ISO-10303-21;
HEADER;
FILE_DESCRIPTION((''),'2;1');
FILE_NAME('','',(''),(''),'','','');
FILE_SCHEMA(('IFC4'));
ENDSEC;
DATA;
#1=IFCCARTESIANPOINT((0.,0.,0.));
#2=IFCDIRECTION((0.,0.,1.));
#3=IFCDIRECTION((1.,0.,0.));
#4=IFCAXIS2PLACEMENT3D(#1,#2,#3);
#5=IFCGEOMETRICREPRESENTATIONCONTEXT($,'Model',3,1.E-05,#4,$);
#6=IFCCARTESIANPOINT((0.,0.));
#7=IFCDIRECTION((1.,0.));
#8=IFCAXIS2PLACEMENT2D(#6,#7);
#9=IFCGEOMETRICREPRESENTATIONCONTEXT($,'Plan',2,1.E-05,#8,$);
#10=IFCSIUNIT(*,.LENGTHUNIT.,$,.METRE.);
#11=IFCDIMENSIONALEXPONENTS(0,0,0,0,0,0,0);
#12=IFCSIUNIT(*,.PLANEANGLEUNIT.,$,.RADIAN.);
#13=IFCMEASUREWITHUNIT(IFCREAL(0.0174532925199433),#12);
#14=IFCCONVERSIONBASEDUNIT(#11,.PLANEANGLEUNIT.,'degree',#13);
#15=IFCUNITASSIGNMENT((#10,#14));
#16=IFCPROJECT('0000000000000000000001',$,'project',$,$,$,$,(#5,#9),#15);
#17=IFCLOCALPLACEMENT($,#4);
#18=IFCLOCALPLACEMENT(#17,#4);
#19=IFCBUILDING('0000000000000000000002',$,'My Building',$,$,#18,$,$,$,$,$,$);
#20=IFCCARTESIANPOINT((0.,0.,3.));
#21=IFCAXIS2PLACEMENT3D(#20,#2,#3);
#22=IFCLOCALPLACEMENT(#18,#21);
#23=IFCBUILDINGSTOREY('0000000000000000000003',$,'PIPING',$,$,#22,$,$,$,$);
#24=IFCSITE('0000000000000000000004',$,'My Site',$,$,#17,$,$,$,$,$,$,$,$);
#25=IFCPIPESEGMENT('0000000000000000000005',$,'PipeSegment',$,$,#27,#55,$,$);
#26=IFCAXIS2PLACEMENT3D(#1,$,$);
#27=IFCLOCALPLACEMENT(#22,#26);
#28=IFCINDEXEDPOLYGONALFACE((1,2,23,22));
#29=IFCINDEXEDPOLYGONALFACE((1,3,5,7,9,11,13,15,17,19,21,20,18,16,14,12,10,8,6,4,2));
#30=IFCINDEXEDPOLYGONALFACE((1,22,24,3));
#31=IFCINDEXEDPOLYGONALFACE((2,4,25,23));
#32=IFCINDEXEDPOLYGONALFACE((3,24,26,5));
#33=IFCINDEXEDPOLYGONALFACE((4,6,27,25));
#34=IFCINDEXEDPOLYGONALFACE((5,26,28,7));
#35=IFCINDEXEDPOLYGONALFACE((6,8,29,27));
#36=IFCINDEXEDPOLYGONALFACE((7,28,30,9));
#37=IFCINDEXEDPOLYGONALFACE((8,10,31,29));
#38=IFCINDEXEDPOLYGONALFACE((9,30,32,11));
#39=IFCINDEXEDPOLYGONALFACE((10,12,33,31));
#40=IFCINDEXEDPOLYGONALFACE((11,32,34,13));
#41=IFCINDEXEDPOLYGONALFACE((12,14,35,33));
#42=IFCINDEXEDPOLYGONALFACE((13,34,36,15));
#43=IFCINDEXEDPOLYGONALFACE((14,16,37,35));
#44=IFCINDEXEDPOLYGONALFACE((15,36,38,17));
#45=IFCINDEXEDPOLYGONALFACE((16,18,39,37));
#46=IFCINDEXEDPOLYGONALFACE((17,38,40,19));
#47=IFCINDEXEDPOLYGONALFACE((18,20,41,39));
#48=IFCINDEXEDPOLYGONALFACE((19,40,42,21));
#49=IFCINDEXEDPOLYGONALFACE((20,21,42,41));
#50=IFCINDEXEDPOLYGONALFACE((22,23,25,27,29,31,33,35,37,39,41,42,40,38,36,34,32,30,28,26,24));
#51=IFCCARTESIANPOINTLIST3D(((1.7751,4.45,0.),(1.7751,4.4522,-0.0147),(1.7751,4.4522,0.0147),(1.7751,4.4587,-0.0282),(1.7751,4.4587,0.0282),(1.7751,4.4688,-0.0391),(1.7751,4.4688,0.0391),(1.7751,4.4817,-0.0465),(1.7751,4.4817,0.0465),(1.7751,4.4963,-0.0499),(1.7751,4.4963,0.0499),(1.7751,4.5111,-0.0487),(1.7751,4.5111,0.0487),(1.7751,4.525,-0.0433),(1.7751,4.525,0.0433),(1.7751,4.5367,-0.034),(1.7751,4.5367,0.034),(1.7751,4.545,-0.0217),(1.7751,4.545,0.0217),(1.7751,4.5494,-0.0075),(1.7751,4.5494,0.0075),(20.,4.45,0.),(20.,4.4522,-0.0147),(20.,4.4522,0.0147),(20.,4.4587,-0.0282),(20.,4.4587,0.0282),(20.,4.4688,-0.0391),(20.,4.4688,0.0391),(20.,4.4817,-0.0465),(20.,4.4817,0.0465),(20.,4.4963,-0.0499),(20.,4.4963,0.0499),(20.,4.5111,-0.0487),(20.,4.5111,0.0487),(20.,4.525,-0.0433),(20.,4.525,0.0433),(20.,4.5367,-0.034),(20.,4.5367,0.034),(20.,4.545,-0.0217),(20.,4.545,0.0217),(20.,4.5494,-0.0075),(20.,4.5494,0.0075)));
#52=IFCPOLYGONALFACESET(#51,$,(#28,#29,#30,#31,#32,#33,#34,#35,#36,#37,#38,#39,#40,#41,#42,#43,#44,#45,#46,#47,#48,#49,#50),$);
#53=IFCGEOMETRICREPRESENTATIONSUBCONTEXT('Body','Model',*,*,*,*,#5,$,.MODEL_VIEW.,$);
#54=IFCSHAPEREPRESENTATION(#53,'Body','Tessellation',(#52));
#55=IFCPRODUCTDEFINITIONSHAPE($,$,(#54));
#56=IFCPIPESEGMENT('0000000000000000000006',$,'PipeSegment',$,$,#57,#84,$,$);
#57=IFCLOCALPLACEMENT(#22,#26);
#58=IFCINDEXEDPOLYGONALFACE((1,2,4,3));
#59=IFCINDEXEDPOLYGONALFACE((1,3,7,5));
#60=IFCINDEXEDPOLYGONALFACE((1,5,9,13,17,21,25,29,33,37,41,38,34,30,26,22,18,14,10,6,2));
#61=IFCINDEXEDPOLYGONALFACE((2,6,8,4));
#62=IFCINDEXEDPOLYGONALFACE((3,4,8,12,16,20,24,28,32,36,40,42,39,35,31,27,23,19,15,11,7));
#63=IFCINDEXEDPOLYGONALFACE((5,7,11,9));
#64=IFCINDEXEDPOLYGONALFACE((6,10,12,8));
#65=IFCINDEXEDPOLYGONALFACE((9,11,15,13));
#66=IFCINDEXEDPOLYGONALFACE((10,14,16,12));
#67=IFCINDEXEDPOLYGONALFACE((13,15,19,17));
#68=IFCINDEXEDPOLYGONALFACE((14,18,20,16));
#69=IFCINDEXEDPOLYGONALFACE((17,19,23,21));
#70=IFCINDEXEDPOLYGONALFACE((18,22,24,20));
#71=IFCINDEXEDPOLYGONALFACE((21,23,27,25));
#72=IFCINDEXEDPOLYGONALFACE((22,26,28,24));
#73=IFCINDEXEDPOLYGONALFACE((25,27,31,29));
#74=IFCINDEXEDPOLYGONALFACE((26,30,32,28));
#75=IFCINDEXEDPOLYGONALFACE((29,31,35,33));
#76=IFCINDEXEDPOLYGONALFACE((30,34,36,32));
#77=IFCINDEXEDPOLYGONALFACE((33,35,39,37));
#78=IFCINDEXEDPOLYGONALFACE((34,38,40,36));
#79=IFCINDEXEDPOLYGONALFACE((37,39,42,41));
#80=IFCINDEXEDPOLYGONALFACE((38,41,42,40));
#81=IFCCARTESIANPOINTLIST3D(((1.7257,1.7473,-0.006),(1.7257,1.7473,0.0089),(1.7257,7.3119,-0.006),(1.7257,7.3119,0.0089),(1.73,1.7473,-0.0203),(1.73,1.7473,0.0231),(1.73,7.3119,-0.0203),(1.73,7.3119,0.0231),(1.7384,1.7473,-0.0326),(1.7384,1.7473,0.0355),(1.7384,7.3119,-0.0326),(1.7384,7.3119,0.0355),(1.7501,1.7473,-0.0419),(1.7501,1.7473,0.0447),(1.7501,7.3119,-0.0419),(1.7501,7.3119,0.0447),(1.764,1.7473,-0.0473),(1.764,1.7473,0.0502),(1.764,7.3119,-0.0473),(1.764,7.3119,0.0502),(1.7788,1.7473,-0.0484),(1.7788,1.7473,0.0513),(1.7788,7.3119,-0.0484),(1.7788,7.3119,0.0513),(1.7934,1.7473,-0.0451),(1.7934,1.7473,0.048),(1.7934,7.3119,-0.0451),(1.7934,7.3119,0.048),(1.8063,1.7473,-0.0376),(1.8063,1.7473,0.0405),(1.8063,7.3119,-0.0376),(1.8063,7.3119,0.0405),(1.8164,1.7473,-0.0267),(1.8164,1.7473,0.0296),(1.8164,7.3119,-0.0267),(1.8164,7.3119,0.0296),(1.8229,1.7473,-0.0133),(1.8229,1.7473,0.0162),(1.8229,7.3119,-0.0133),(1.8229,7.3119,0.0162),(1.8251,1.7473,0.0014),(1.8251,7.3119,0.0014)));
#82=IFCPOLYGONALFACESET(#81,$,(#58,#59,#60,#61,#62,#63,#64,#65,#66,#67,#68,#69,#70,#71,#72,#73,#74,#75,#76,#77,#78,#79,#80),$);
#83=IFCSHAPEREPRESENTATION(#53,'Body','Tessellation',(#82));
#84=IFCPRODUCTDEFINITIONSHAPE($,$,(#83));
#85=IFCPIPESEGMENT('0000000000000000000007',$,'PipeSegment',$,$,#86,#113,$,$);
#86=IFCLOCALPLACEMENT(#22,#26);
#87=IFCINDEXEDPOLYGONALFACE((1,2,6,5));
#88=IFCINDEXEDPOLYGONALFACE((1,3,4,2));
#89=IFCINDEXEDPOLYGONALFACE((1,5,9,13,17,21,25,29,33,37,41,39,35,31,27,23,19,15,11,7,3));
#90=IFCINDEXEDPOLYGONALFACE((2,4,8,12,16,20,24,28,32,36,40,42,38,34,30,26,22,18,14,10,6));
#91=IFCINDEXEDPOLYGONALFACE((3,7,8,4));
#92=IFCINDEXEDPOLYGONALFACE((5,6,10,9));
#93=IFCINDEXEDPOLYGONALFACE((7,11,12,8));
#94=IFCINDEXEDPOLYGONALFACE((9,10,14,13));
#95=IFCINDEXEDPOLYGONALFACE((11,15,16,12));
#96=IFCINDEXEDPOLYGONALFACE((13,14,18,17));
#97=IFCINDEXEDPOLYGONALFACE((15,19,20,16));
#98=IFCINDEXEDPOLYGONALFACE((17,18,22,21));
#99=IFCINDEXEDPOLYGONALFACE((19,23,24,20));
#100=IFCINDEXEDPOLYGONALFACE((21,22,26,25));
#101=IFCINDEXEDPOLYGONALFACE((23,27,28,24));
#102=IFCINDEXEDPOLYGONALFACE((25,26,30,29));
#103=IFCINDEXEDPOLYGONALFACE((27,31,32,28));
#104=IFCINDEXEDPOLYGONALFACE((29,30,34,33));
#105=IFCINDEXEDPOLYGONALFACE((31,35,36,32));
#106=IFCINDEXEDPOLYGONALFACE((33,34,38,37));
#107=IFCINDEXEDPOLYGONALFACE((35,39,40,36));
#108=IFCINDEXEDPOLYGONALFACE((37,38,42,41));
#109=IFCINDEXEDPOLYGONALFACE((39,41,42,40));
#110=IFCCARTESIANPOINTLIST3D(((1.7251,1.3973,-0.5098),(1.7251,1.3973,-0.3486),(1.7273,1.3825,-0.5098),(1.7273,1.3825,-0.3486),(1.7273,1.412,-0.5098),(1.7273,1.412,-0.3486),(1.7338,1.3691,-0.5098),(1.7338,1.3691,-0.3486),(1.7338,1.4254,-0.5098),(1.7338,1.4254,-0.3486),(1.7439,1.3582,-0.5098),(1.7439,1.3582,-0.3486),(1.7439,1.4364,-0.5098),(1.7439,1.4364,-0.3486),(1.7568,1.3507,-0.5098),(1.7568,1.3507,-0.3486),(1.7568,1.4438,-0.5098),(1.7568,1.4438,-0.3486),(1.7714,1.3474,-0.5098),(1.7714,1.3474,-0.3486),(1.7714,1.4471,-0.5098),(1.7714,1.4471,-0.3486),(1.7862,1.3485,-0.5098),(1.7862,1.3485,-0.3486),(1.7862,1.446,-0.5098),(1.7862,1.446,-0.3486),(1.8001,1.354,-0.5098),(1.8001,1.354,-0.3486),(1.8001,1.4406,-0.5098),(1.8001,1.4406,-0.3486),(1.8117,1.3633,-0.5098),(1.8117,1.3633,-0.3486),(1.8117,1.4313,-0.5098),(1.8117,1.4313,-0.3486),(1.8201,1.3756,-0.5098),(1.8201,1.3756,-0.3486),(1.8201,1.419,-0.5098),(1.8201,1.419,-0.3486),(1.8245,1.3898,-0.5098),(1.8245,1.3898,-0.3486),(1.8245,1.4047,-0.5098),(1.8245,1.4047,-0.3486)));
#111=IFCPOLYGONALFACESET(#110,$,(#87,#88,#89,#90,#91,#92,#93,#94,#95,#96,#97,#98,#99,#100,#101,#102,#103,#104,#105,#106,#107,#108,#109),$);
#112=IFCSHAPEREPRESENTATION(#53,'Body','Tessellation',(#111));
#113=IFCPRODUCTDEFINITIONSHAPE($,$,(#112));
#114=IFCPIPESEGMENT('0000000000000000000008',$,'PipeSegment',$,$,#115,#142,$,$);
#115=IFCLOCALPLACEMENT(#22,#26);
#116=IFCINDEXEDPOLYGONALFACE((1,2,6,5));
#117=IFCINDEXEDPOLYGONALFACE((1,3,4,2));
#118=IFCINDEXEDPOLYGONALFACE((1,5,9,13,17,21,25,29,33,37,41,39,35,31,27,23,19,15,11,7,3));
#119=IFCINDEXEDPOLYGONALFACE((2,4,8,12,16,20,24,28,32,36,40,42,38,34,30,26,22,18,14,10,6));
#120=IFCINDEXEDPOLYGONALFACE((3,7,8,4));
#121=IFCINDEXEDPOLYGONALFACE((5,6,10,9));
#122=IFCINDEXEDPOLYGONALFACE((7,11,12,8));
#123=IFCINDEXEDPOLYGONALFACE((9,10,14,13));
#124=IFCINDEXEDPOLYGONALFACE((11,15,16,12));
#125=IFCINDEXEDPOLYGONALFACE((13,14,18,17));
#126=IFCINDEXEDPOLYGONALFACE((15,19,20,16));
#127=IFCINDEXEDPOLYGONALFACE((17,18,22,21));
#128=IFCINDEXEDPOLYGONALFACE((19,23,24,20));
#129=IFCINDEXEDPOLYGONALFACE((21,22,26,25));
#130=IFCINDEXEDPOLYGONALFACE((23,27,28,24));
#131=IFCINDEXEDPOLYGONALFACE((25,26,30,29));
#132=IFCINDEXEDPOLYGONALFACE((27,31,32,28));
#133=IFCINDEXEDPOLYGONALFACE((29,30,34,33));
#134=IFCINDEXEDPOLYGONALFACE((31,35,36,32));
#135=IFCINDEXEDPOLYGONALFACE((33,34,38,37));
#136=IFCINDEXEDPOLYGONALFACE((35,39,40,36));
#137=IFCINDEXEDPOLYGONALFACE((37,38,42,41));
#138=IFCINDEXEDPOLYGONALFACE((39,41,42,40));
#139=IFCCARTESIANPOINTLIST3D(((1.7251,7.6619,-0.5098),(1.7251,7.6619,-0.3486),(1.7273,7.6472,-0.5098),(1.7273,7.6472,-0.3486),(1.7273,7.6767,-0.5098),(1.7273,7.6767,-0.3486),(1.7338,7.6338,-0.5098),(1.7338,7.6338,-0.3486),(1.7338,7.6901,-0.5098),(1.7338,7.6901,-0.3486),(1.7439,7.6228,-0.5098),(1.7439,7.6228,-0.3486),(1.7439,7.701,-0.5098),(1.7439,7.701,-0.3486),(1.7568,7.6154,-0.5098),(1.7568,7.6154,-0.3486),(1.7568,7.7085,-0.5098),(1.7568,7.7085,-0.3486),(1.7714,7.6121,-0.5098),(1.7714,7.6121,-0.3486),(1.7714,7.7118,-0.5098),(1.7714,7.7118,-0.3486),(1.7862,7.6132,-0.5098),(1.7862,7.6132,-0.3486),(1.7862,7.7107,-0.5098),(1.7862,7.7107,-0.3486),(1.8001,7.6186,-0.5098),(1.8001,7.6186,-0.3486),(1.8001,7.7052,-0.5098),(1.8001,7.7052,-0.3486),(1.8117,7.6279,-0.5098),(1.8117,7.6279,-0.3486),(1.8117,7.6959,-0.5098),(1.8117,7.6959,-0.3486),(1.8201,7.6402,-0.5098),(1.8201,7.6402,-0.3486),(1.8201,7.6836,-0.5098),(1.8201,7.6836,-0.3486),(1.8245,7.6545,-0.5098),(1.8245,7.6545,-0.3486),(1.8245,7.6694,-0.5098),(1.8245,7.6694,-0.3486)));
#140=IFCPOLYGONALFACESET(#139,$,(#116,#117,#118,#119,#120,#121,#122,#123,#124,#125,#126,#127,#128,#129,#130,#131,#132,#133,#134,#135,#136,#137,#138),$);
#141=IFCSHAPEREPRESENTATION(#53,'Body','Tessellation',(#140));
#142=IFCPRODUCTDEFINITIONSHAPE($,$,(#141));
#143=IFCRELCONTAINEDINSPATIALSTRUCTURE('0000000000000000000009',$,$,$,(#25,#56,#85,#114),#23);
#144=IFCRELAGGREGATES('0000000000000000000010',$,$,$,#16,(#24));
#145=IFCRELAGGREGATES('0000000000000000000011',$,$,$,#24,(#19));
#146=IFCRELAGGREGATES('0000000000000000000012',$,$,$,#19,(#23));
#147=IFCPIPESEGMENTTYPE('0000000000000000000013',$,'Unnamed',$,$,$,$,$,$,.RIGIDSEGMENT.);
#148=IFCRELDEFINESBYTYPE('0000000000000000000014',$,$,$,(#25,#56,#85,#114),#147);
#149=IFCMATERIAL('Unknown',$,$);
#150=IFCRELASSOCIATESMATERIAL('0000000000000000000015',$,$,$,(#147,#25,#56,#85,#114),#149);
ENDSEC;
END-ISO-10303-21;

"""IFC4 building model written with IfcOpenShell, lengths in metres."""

from ifc_helpers import new_model, entity, si_unit, converted_unit, frame, origin_with_axes, origin_2d_with_axis, place, context, subcontext, project, spatial, circle, extrude, material, material_profile, profile_set, profile_usage, type_object, element, save


model = new_model("IFC4")

# Units and contexts
model_context = context("Model", 3, precision=1e-05, world=origin_with_axes())
plan_context = context("Plan", 2, precision=1e-05, world=origin_2d_with_axis())
body_context = subcontext(model_context, "Body", "Model", "MODEL_VIEW")
ifc_project = project(units=[si_unit("LENGTHUNIT", "METRE"), converted_unit("PLANEANGLEUNIT", "degree", entity("IfcReal", 0.0174532925199433), si_unit("PLANEANGLEUNIT", "RADIAN"), dimensions=[0, 0, 0, 0, 0, 0, 0])], contexts=[model_context, plan_context])

# Site, building, storey
site_placement = place(None, origin_with_axes())
site = spatial("IfcSite", under=ifc_project, at=site_placement, Name="My Site")
building_placement = place(site_placement, origin_with_axes())
building = spatial("IfcBuilding", under=site, at=building_placement, Name="My Building")
storey_placement = place(building_placement, frame((0.0, 0.0, 3.0), z_axis=(0.0, 0.0, 1.0), x_axis=(1.0, 0.0, 0.0)))
storey = spatial("IfcBuildingStorey", under=building, at=storey_placement, Name="PIPING")

# Pipe segments
ifc_material = material(Name="Unknown")
ifc_material_profile = material_profile(ifc_material, circle(Radius=0.05))
ifc_profile_set = profile_set([ifc_material_profile])
ifc_profile_usage_1 = profile_usage(ifc_profile_set, cardinal=5)
pipe_segment_type = type_object("IfcPipeSegmentType", Name="Unnamed", PredefinedType="RIGIDSEGMENT", material=ifc_profile_set)
pipe_segment_1_placement = place(storey_placement, frame((20.0, 4.5, 0.0), z_axis=(-1.0, 0.0, 0.0), x_axis=(0.0, -1.0, 0.0)))
element("IfcPipeSegment", 1, at=pipe_segment_1_placement, inside=storey, type_object=pipe_segment_type, material=ifc_profile_usage_1, Name="PipeSegment", context=body_context, shape_type="SweptSolid", body=[
    extrude(circle(Radius=0.05), origin_with_axes(), (0.0, 0.0, 1.0), 18.2249),
])
ifc_profile_usage_2 = profile_usage(ifc_profile_set, cardinal=5)
pipe_segment_2_placement = place(storey_placement, frame((1.7751, 1.7473, 0.0014), z_axis=(0.0, 1.0, 0.0), x_axis=(1.0, 0.0, 0.0)))
element("IfcPipeSegment", 2, at=pipe_segment_2_placement, inside=storey, type_object=pipe_segment_type, material=ifc_profile_usage_2, Name="PipeSegment", context=body_context, shape_type="SweptSolid", body=[
    extrude(circle(Radius=0.05), origin_with_axes(), (0.0, 0.0, 1.0), 5.5647),
])
ifc_profile_usage_3 = profile_usage(ifc_profile_set, cardinal=5)
pipe_segment_3_placement = place(storey_placement, frame((1.7751, 1.3973, -0.3486), z_axis=(0.0, 0.0, -1.0), x_axis=(-1.0, 0.0, 0.0)))
element("IfcPipeSegment", 3, at=pipe_segment_3_placement, inside=storey, type_object=pipe_segment_type, material=ifc_profile_usage_3, Name="PipeSegment", context=body_context, shape_type="SweptSolid", body=[
    extrude(circle(Radius=0.05), origin_with_axes(), (0.0, 0.0, 1.0), 0.1612),
])
ifc_profile_usage_4 = profile_usage(ifc_profile_set, cardinal=5)
pipe_segment_4_placement = place(storey_placement, frame((1.7751, 7.6619, -0.3486), z_axis=(0.0, 0.0, -1.0), x_axis=(-1.0, 0.0, 0.0)))
element("IfcPipeSegment", 4, at=pipe_segment_4_placement, inside=storey, type_object=pipe_segment_type, material=ifc_profile_usage_4, Name="PipeSegment", context=body_context, shape_type="SweptSolid", body=[
    extrude(circle(Radius=0.05), origin_with_axes(), (0.0, 0.0, 1.0), 0.1612),
])

save(model, "model.ifc")
